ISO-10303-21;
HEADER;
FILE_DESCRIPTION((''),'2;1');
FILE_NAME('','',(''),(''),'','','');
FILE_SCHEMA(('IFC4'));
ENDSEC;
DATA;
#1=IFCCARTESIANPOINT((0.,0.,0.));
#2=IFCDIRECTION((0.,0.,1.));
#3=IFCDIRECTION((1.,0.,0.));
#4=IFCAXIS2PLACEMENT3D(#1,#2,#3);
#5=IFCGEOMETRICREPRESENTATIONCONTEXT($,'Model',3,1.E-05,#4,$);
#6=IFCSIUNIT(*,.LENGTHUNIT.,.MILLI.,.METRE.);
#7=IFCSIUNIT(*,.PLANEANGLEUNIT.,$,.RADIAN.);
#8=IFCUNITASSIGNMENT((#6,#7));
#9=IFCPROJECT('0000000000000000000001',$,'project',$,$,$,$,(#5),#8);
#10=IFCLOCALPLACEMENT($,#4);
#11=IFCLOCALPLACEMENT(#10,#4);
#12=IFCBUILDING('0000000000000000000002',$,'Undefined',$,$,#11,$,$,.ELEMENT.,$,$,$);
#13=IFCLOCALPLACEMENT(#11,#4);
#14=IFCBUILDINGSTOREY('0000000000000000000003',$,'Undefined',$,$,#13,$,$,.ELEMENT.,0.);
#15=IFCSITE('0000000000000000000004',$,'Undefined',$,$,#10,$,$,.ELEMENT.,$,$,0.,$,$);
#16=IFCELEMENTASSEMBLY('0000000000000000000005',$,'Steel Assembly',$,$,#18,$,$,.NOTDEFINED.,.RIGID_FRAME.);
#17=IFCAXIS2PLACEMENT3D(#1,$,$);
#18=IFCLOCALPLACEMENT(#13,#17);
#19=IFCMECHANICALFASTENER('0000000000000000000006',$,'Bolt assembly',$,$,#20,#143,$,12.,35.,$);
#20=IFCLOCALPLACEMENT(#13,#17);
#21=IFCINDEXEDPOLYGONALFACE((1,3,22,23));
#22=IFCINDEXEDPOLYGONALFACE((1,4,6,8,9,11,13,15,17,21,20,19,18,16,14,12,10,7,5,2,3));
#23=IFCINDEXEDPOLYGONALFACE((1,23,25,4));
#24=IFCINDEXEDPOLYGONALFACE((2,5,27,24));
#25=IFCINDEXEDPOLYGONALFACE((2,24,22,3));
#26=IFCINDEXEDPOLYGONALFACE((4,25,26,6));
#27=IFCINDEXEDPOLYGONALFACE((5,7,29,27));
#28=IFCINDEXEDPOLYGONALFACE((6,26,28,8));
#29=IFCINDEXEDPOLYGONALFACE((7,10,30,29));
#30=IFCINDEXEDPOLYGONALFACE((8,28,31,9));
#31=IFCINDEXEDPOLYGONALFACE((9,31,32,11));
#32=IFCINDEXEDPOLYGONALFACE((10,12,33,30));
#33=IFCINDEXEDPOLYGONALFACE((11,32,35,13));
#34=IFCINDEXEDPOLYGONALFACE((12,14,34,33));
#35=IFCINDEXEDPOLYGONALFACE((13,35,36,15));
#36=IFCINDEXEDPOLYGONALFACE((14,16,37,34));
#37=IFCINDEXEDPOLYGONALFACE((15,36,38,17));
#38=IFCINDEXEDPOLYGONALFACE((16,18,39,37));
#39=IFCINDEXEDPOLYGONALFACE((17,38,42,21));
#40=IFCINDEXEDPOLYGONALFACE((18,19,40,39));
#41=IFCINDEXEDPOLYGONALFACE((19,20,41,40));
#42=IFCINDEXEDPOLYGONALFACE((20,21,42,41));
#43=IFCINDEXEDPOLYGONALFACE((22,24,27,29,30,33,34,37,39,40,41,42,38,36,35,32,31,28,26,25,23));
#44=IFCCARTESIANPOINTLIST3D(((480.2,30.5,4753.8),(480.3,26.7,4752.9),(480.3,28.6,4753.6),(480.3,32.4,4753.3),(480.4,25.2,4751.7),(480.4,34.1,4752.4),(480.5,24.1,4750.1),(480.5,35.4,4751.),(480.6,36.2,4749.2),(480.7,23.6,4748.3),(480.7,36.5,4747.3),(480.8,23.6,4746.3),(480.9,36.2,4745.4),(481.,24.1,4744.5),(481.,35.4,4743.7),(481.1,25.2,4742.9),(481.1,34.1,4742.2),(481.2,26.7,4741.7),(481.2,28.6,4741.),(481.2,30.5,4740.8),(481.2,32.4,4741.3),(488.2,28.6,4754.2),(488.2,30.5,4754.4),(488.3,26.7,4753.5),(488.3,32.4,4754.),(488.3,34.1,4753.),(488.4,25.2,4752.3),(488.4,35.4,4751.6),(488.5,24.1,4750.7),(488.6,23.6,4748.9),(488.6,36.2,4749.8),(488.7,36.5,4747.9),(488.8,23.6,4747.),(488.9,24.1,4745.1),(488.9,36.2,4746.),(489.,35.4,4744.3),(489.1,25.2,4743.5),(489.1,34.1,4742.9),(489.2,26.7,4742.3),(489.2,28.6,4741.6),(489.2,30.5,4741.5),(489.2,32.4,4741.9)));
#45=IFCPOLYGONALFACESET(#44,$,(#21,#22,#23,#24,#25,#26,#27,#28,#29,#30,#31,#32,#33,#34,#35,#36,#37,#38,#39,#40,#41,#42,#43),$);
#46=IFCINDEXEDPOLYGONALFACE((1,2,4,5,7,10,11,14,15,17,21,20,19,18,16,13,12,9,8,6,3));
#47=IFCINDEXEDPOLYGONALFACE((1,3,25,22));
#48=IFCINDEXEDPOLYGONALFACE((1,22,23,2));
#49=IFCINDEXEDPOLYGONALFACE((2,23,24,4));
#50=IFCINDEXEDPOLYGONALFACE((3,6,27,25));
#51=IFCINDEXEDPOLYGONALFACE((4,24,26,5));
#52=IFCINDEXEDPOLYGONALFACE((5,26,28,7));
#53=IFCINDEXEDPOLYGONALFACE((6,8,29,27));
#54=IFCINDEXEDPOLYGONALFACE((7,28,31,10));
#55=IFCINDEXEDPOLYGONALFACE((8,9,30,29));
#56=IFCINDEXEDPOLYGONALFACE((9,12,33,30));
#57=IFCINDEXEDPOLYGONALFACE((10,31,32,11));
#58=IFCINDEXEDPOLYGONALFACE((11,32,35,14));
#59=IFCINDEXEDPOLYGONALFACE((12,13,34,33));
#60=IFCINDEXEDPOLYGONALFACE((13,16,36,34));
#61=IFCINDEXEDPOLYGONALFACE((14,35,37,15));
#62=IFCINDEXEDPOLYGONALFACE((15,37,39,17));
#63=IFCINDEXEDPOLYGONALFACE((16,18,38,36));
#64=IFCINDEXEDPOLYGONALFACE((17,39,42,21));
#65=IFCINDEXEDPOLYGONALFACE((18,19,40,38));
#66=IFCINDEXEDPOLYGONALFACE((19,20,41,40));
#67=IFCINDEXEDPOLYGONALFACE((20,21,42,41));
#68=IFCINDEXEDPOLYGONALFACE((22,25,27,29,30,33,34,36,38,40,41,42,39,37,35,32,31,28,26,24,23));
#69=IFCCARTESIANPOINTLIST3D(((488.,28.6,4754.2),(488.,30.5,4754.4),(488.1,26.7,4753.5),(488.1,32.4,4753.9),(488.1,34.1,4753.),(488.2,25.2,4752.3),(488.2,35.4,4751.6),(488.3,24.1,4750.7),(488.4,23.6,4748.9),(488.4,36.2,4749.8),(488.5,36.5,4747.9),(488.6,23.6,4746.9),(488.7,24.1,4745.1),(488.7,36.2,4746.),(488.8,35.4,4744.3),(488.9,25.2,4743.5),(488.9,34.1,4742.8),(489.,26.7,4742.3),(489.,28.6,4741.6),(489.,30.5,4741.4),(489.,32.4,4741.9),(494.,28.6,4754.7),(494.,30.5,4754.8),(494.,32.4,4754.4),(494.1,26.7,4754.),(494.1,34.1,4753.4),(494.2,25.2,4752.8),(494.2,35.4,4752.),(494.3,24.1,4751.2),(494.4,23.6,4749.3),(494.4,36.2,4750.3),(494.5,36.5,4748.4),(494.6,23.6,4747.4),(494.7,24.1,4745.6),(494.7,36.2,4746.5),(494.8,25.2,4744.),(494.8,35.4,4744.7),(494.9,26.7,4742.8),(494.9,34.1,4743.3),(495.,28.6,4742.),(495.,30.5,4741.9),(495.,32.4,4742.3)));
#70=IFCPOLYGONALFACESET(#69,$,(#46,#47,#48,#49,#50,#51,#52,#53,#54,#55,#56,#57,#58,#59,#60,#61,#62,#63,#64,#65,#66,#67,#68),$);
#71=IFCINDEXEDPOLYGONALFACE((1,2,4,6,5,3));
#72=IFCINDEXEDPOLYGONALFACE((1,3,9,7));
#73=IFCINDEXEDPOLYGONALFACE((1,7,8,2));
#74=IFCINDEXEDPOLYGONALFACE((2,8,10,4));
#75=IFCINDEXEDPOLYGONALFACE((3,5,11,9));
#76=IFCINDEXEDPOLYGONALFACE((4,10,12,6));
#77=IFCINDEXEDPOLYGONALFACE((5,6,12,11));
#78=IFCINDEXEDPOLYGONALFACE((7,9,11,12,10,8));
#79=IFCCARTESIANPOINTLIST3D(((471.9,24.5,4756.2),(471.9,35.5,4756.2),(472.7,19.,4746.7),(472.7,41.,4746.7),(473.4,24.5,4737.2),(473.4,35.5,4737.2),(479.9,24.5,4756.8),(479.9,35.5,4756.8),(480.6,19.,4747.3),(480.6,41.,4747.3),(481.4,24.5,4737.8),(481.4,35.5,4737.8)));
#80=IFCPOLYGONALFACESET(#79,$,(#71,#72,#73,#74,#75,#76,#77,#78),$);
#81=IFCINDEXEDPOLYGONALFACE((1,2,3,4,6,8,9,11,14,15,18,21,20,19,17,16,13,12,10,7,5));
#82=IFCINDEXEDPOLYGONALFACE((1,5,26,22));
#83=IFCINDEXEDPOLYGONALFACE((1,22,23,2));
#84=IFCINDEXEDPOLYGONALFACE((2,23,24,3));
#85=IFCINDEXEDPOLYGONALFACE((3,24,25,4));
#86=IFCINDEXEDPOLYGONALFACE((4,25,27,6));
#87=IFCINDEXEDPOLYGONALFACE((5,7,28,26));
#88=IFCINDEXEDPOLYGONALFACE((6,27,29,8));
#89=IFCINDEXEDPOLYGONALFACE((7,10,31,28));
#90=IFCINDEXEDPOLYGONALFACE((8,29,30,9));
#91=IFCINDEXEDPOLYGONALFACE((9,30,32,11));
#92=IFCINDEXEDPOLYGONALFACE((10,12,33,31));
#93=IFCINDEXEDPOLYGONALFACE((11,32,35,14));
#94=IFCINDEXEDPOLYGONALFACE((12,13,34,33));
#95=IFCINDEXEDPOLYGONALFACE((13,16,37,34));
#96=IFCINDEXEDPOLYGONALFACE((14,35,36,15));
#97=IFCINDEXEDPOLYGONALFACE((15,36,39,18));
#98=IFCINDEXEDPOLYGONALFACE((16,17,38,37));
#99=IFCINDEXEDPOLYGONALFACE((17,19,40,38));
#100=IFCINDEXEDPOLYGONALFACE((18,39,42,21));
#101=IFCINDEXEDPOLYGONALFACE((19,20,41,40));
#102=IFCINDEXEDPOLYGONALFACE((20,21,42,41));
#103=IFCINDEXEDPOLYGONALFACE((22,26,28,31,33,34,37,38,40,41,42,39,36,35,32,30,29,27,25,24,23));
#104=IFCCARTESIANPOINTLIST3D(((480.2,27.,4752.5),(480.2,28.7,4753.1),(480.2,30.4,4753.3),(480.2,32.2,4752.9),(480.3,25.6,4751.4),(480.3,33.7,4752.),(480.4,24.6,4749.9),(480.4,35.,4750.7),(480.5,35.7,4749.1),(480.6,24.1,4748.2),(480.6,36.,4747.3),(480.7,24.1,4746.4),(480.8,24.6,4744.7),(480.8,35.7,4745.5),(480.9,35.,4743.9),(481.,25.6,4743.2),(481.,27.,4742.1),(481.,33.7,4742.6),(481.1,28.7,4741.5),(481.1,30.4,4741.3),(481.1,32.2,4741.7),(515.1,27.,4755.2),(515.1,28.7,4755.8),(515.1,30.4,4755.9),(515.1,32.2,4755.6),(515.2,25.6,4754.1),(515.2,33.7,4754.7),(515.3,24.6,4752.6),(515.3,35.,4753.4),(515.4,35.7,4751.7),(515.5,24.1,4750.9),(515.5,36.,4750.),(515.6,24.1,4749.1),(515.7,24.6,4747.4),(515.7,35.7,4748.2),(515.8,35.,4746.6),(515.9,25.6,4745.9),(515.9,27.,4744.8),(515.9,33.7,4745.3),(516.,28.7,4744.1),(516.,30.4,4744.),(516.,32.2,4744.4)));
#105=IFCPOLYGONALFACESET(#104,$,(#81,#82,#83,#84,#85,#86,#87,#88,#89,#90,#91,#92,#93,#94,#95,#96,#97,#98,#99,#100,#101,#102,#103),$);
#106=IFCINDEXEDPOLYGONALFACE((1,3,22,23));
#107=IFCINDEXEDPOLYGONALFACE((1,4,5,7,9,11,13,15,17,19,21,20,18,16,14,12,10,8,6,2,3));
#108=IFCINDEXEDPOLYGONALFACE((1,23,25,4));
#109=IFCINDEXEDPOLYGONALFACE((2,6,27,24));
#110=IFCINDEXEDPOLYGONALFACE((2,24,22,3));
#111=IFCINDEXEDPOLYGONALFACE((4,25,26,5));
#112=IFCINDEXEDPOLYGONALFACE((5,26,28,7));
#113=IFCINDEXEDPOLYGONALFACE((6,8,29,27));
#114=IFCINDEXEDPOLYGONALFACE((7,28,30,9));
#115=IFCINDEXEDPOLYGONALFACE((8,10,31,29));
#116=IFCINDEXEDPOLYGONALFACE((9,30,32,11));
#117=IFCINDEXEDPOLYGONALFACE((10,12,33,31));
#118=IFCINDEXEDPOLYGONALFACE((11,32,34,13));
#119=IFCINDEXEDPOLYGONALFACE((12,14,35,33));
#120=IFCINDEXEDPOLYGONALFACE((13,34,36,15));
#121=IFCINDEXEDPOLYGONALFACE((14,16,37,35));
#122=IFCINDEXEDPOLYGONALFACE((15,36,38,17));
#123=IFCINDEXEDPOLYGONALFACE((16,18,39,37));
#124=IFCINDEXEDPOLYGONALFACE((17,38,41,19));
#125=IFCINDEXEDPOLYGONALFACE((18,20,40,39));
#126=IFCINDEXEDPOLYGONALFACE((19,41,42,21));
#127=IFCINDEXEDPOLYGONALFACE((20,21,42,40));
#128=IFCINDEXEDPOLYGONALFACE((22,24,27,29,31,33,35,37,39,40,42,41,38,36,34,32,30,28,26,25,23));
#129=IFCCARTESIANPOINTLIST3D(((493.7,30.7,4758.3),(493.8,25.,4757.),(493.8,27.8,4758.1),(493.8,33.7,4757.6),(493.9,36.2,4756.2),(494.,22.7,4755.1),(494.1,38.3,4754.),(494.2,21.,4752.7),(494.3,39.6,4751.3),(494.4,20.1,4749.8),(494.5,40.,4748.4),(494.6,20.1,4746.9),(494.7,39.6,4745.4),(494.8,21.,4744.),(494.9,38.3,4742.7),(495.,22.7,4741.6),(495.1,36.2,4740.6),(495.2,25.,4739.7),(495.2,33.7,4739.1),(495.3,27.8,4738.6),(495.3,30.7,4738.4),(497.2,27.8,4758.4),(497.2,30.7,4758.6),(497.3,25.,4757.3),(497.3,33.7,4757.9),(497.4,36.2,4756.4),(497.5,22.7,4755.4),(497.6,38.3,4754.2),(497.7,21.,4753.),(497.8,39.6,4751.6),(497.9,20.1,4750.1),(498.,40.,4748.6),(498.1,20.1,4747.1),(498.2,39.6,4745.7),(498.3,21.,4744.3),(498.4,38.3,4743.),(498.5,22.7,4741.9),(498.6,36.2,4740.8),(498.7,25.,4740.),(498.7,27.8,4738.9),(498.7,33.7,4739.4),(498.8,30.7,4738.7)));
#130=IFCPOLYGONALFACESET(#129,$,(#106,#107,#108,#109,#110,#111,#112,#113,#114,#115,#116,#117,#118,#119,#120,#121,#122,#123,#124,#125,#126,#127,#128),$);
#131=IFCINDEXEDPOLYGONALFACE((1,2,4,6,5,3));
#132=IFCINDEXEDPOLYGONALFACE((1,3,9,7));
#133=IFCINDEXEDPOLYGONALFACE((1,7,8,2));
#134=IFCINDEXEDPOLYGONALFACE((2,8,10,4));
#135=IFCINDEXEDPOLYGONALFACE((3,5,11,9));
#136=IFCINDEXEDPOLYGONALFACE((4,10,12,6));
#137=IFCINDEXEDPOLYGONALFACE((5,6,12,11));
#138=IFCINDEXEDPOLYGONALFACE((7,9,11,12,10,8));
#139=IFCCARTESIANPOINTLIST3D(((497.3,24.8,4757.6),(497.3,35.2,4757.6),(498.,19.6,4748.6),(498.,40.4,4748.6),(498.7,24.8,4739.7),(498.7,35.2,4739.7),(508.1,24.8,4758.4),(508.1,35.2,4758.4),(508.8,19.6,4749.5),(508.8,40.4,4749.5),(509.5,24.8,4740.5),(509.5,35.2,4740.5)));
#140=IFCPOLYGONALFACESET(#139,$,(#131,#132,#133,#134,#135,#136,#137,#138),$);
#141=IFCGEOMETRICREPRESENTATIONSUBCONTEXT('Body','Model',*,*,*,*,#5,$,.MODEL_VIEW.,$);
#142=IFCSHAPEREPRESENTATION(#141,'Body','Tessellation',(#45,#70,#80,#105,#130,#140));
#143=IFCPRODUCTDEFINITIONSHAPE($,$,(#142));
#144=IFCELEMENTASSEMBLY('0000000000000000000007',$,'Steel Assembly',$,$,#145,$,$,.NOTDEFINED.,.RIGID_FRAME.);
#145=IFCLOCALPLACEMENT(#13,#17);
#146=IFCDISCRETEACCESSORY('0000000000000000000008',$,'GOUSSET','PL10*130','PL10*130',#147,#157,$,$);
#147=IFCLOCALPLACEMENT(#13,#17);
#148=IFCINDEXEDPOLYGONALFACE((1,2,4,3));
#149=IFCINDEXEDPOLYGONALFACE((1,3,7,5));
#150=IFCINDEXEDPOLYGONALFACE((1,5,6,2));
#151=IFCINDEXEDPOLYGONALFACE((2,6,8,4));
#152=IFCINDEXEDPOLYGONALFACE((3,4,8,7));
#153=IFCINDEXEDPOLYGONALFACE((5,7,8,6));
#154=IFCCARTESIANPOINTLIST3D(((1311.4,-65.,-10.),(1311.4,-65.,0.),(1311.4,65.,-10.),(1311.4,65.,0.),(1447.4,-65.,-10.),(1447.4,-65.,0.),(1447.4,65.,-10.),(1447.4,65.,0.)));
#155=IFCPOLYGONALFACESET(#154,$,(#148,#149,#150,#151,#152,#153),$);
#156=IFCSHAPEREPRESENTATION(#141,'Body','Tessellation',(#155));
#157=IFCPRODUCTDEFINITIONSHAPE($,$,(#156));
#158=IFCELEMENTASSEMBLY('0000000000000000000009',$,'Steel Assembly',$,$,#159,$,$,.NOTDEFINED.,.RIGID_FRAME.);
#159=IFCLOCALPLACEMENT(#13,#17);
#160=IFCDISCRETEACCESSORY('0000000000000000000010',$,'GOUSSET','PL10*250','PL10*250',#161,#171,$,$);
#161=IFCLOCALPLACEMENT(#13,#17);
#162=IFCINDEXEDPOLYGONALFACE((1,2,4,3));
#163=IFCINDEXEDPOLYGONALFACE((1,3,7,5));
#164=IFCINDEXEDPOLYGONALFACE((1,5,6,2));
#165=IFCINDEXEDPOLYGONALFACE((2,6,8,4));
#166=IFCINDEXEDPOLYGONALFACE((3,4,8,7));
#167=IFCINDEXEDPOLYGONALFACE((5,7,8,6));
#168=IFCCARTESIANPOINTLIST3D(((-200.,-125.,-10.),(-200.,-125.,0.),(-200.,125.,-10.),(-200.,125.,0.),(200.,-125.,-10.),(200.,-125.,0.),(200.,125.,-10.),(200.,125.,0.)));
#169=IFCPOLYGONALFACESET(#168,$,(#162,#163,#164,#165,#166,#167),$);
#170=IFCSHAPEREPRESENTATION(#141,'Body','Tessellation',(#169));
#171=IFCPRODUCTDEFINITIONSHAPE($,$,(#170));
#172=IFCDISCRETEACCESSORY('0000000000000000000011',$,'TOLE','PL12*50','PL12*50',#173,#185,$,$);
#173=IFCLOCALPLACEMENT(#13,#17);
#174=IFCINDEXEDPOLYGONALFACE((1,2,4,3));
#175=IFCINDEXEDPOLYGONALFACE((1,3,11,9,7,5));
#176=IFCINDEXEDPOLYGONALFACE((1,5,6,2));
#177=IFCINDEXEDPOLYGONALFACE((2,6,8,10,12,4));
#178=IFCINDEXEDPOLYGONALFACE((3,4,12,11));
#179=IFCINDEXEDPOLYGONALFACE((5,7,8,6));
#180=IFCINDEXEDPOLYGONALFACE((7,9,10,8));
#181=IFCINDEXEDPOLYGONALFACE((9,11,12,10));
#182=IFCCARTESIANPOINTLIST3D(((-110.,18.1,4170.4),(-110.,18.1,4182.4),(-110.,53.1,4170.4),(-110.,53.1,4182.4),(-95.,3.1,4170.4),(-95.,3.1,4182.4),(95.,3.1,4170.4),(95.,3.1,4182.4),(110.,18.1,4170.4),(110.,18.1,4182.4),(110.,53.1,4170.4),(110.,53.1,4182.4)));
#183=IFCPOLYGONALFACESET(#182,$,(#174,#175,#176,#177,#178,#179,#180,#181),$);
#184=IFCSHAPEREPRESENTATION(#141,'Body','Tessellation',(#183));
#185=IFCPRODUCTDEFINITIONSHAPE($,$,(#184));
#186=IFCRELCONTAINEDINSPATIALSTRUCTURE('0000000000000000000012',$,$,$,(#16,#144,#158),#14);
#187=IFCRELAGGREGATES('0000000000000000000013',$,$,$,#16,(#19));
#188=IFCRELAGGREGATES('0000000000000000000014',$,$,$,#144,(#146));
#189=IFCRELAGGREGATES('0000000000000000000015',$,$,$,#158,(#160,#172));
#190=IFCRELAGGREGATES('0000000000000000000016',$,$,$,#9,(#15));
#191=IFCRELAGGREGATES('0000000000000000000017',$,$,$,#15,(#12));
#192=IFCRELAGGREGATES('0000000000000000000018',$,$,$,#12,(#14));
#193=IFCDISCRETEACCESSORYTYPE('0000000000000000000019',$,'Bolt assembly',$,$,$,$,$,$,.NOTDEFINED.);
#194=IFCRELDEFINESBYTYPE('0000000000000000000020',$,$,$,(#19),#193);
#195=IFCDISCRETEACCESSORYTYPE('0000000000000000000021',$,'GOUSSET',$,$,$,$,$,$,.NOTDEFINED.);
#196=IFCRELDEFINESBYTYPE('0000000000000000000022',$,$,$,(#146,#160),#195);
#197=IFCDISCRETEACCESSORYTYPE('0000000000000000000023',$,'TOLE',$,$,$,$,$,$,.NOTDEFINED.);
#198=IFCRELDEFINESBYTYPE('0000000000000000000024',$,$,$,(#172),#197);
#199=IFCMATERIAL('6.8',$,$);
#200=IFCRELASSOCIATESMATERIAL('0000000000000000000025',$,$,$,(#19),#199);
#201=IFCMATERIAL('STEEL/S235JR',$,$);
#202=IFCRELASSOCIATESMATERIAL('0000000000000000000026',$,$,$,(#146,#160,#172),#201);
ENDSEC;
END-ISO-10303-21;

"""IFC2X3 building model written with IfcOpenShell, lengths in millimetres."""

from ifc_helpers import new_model, si_unit, frame, origin_with_axes, origin_2d_with_axis, place, context, subcontext, project, spatial, polyline, rectangle, circle, outline, extrude, clip, halfspace, source, transform, mapped, material, type_object, element, aggregate, save


model = new_model("IFC2X3")

# Units and contexts
model_context = context("Model", 3, precision=1e-05, world=origin_with_axes())
body_context = subcontext(model_context, "Body", "Model", "MODEL_VIEW")
ifc_project = project(units=[si_unit("LENGTHUNIT", "METRE", prefix="MILLI"), si_unit("PLANEANGLEUNIT", "RADIAN")], contexts=[model_context])

# Site, building, storey
site_placement = place(None, origin_with_axes())
site = spatial("IfcSite", under=ifc_project, at=site_placement, Name="Undefined", CompositionType="ELEMENT", RefElevation=0.0)
building_placement = place(site_placement, origin_with_axes())
building = spatial("IfcBuilding", under=site, at=building_placement, Name="Undefined", CompositionType="ELEMENT")
storey_placement = place(building_placement, origin_with_axes())
storey = spatial("IfcBuildingStorey", under=building, at=storey_placement, Name="Undefined", CompositionType="ELEMENT", Elevation=0.0)

# Shared definitions
ifc_material_1 = material(Name="STEEL/S235JR")

# Element assembly, mechanical fastener
ifc_material_2 = material(Name="6.8")
discrete_accessory_type_1 = type_object("IfcDiscreteAccessoryType", Name="Bolt assembly")
assembly_1_placement = place(storey_placement, origin_with_axes())
assembly_1 = element("IfcElementAssembly", 1, at=assembly_1_placement, inside=storey, Name="Steel Assembly", AssemblyPlace="NOTDEFINED", PredefinedType="RIGID_FRAME")
shared_shape_1 = source(origin_with_axes(), body_context, "Body", "SweptSolid", [
    extrude(circle(Radius=6.5, at=origin_2d_with_axis()), frame((0.0, -10.9, 0.0), z_axis=(0.0, 1.0, 0.0), x_axis=(1.0, 0.0, 0.0)), (0.0, 0.0, 1.0), 8.0),
    extrude(circle(Radius=6.5, at=origin_2d_with_axis()), frame((0.0, -3.1, 0.0), z_axis=(0.0, 1.0, 0.0), x_axis=(1.0, 0.0, 0.0)), (0.0, 0.0, 1.0), 6.0),
    extrude(outline(polyline([(11.0, 0.0), (5.5, 9.5), (-5.5, 9.5), (-11.0, 0.0), (-5.5, -9.5), (5.5, -9.5), (11.0, 0.0)])), frame((0.0, -19.0, 0.0), z_axis=(0.0, 1.0, 0.0), x_axis=(1.0, 0.0, 0.0)), (0.0, 0.0, 1.0), 8.0),
    extrude(circle(Radius=6.0, at=origin_2d_with_axis()), frame((0.0, -11.0, 0.0), z_axis=(0.0, 1.0, 0.0), x_axis=(1.0, 0.0, 0.0)), (0.0, 0.0, 1.0), 35.0),
    extrude(circle(Radius=10.0, at=origin_2d_with_axis()), frame((0.0, 3.0, 0.0), z_axis=(0.0, 1.0, 0.0), x_axis=(1.0, 0.0, 0.0)), (0.0, 0.0, 1.0), 3.5),
    extrude(outline(polyline([(10.4, 0.0), (5.2, 9.0), (-5.2, 9.0), (-10.4, 0.0), (-5.2, -9.0), (5.2, -9.0), (10.4, 0.0)])), frame((0.0, 6.5, 0.0), z_axis=(0.0, 1.0, 0.0), x_axis=(1.0, 0.0, 0.0)), (0.0, 0.0, 1.0), 10.8),
])
mechanical_fastener_1_placement = place(assembly_1_placement, frame((491.6, 30.0, 4748.1), z_axis=(0.076696, 0.0, -0.997054), x_axis=(0.0, 1.0, 0.0)))
mechanical_fastener_1 = element("IfcMechanicalFastener", 2, at=mechanical_fastener_1_placement, type_object=discrete_accessory_type_1, material=ifc_material_2, Name="Bolt assembly", NominalDiameter=12.0, NominalLength=35.0, context=body_context, shape_type="MappedRepresentation", body=[
    mapped(shared_shape_1, transform((0.0, 0.0, 0.0))),
])
aggregate(assembly_1, [mechanical_fastener_1])

# Element assembly, discrete accessory
assembly_2_placement = place(storey_placement, origin_with_axes())
assembly_2 = element("IfcElementAssembly", 3, at=assembly_2_placement, inside=storey, Name="Steel Assembly", AssemblyPlace="NOTDEFINED", PredefinedType="RIGID_FRAME")
discrete_accessory_type_2 = type_object("IfcDiscreteAccessoryType", Name="GOUSSET")
discrete_accessory_1_placement = place(assembly_2_placement, frame((1447.4, 65.0, -5.0), z_axis=(0.0, 0.0, 1.0), x_axis=(-1.0, 0.0, 0.0)))
discrete_accessory_1 = element("IfcDiscreteAccessory", 4, at=discrete_accessory_1_placement, type_object=discrete_accessory_type_2, material=ifc_material_1, Name="GOUSSET", Description="PL10*130", ObjectType="PL10*130", context=body_context, shape_type="SweptSolid", body=[
    extrude(outline(polyline([(0.0, 0.0), (136.0, 0.0), (136.0, 130.0), (0.0, 130.0), (0.0, 0.0)])), frame((0.0, 0.0, -5.0), z_axis=(0.0, 0.0, 1.0), x_axis=(1.0, 0.0, 0.0)), (0.0, 0.0, 1.0), 10.0),
])
aggregate(assembly_2, [discrete_accessory_1])

# Element assembly, discrete accessories
assembly_3_placement = place(storey_placement, origin_with_axes())
assembly_3 = element("IfcElementAssembly", 5, at=assembly_3_placement, inside=storey, Name="Steel Assembly", AssemblyPlace="NOTDEFINED", PredefinedType="RIGID_FRAME")
discrete_accessory_2_placement = place(assembly_3_placement, frame((-200.0, 125.0, -5.0), z_axis=(0.0, 0.0, 1.0), x_axis=(0.0, -1.0, 0.0)))
discrete_accessory_2 = element("IfcDiscreteAccessory", 6, at=discrete_accessory_2_placement, type_object=discrete_accessory_type_2, material=ifc_material_1, Name="GOUSSET", Description="PL10*250", ObjectType="PL10*250", context=body_context, shape_type="SweptSolid", body=[
    extrude(outline(polyline([(0.0, 0.0), (250.0, 0.0), (250.0, 400.0), (0.0, 400.0), (0.0, 0.0)])), frame((0.0, 0.0, -5.0), z_axis=(0.0, 0.0, 1.0), x_axis=(1.0, 0.0, 0.0)), (0.0, 0.0, 1.0), 10.0),
])
discrete_accessory_type_3 = type_object("IfcDiscreteAccessoryType", Name="TOLE")
discrete_accessory_3_placement = place(assembly_3_placement, frame((-110.0, 28.1, 4176.4), z_axis=(0.0, -1.0, 0.0), x_axis=(1.0, 0.0, 0.0)))
discrete_accessory_3 = element("IfcDiscreteAccessory", 7, at=discrete_accessory_3_placement, type_object=discrete_accessory_type_3, material=ifc_material_1, Name="TOLE", Description="PL12*50", ObjectType="PL12*50", context=body_context, shape_type="Clipping", body=[
    clip(clip(extrude(rectangle(XDim=12.0, YDim=50.0, at=origin_2d_with_axis()), frame((220.0, 0.0, 0.0), z_axis=(-1.0, 0.0, 0.0), x_axis=(0.0, -1.0, 0.0)), (0.0, 0.0, 1.0), 220.0), halfspace(frame((-35.0, 6.0, -25.0), z_axis=(-0.707107, 0.0, 0.707107), x_axis=(0.707107, 0.0, 0.707107)), False)), halfspace(frame((255.0, -6.0, -25.0), z_axis=(0.707107, 0.0, 0.707107), x_axis=(-0.707107, 0.0, 0.707107)), False)),
])
aggregate(assembly_3, [discrete_accessory_2, discrete_accessory_3])

save(model, "model.ifc")
